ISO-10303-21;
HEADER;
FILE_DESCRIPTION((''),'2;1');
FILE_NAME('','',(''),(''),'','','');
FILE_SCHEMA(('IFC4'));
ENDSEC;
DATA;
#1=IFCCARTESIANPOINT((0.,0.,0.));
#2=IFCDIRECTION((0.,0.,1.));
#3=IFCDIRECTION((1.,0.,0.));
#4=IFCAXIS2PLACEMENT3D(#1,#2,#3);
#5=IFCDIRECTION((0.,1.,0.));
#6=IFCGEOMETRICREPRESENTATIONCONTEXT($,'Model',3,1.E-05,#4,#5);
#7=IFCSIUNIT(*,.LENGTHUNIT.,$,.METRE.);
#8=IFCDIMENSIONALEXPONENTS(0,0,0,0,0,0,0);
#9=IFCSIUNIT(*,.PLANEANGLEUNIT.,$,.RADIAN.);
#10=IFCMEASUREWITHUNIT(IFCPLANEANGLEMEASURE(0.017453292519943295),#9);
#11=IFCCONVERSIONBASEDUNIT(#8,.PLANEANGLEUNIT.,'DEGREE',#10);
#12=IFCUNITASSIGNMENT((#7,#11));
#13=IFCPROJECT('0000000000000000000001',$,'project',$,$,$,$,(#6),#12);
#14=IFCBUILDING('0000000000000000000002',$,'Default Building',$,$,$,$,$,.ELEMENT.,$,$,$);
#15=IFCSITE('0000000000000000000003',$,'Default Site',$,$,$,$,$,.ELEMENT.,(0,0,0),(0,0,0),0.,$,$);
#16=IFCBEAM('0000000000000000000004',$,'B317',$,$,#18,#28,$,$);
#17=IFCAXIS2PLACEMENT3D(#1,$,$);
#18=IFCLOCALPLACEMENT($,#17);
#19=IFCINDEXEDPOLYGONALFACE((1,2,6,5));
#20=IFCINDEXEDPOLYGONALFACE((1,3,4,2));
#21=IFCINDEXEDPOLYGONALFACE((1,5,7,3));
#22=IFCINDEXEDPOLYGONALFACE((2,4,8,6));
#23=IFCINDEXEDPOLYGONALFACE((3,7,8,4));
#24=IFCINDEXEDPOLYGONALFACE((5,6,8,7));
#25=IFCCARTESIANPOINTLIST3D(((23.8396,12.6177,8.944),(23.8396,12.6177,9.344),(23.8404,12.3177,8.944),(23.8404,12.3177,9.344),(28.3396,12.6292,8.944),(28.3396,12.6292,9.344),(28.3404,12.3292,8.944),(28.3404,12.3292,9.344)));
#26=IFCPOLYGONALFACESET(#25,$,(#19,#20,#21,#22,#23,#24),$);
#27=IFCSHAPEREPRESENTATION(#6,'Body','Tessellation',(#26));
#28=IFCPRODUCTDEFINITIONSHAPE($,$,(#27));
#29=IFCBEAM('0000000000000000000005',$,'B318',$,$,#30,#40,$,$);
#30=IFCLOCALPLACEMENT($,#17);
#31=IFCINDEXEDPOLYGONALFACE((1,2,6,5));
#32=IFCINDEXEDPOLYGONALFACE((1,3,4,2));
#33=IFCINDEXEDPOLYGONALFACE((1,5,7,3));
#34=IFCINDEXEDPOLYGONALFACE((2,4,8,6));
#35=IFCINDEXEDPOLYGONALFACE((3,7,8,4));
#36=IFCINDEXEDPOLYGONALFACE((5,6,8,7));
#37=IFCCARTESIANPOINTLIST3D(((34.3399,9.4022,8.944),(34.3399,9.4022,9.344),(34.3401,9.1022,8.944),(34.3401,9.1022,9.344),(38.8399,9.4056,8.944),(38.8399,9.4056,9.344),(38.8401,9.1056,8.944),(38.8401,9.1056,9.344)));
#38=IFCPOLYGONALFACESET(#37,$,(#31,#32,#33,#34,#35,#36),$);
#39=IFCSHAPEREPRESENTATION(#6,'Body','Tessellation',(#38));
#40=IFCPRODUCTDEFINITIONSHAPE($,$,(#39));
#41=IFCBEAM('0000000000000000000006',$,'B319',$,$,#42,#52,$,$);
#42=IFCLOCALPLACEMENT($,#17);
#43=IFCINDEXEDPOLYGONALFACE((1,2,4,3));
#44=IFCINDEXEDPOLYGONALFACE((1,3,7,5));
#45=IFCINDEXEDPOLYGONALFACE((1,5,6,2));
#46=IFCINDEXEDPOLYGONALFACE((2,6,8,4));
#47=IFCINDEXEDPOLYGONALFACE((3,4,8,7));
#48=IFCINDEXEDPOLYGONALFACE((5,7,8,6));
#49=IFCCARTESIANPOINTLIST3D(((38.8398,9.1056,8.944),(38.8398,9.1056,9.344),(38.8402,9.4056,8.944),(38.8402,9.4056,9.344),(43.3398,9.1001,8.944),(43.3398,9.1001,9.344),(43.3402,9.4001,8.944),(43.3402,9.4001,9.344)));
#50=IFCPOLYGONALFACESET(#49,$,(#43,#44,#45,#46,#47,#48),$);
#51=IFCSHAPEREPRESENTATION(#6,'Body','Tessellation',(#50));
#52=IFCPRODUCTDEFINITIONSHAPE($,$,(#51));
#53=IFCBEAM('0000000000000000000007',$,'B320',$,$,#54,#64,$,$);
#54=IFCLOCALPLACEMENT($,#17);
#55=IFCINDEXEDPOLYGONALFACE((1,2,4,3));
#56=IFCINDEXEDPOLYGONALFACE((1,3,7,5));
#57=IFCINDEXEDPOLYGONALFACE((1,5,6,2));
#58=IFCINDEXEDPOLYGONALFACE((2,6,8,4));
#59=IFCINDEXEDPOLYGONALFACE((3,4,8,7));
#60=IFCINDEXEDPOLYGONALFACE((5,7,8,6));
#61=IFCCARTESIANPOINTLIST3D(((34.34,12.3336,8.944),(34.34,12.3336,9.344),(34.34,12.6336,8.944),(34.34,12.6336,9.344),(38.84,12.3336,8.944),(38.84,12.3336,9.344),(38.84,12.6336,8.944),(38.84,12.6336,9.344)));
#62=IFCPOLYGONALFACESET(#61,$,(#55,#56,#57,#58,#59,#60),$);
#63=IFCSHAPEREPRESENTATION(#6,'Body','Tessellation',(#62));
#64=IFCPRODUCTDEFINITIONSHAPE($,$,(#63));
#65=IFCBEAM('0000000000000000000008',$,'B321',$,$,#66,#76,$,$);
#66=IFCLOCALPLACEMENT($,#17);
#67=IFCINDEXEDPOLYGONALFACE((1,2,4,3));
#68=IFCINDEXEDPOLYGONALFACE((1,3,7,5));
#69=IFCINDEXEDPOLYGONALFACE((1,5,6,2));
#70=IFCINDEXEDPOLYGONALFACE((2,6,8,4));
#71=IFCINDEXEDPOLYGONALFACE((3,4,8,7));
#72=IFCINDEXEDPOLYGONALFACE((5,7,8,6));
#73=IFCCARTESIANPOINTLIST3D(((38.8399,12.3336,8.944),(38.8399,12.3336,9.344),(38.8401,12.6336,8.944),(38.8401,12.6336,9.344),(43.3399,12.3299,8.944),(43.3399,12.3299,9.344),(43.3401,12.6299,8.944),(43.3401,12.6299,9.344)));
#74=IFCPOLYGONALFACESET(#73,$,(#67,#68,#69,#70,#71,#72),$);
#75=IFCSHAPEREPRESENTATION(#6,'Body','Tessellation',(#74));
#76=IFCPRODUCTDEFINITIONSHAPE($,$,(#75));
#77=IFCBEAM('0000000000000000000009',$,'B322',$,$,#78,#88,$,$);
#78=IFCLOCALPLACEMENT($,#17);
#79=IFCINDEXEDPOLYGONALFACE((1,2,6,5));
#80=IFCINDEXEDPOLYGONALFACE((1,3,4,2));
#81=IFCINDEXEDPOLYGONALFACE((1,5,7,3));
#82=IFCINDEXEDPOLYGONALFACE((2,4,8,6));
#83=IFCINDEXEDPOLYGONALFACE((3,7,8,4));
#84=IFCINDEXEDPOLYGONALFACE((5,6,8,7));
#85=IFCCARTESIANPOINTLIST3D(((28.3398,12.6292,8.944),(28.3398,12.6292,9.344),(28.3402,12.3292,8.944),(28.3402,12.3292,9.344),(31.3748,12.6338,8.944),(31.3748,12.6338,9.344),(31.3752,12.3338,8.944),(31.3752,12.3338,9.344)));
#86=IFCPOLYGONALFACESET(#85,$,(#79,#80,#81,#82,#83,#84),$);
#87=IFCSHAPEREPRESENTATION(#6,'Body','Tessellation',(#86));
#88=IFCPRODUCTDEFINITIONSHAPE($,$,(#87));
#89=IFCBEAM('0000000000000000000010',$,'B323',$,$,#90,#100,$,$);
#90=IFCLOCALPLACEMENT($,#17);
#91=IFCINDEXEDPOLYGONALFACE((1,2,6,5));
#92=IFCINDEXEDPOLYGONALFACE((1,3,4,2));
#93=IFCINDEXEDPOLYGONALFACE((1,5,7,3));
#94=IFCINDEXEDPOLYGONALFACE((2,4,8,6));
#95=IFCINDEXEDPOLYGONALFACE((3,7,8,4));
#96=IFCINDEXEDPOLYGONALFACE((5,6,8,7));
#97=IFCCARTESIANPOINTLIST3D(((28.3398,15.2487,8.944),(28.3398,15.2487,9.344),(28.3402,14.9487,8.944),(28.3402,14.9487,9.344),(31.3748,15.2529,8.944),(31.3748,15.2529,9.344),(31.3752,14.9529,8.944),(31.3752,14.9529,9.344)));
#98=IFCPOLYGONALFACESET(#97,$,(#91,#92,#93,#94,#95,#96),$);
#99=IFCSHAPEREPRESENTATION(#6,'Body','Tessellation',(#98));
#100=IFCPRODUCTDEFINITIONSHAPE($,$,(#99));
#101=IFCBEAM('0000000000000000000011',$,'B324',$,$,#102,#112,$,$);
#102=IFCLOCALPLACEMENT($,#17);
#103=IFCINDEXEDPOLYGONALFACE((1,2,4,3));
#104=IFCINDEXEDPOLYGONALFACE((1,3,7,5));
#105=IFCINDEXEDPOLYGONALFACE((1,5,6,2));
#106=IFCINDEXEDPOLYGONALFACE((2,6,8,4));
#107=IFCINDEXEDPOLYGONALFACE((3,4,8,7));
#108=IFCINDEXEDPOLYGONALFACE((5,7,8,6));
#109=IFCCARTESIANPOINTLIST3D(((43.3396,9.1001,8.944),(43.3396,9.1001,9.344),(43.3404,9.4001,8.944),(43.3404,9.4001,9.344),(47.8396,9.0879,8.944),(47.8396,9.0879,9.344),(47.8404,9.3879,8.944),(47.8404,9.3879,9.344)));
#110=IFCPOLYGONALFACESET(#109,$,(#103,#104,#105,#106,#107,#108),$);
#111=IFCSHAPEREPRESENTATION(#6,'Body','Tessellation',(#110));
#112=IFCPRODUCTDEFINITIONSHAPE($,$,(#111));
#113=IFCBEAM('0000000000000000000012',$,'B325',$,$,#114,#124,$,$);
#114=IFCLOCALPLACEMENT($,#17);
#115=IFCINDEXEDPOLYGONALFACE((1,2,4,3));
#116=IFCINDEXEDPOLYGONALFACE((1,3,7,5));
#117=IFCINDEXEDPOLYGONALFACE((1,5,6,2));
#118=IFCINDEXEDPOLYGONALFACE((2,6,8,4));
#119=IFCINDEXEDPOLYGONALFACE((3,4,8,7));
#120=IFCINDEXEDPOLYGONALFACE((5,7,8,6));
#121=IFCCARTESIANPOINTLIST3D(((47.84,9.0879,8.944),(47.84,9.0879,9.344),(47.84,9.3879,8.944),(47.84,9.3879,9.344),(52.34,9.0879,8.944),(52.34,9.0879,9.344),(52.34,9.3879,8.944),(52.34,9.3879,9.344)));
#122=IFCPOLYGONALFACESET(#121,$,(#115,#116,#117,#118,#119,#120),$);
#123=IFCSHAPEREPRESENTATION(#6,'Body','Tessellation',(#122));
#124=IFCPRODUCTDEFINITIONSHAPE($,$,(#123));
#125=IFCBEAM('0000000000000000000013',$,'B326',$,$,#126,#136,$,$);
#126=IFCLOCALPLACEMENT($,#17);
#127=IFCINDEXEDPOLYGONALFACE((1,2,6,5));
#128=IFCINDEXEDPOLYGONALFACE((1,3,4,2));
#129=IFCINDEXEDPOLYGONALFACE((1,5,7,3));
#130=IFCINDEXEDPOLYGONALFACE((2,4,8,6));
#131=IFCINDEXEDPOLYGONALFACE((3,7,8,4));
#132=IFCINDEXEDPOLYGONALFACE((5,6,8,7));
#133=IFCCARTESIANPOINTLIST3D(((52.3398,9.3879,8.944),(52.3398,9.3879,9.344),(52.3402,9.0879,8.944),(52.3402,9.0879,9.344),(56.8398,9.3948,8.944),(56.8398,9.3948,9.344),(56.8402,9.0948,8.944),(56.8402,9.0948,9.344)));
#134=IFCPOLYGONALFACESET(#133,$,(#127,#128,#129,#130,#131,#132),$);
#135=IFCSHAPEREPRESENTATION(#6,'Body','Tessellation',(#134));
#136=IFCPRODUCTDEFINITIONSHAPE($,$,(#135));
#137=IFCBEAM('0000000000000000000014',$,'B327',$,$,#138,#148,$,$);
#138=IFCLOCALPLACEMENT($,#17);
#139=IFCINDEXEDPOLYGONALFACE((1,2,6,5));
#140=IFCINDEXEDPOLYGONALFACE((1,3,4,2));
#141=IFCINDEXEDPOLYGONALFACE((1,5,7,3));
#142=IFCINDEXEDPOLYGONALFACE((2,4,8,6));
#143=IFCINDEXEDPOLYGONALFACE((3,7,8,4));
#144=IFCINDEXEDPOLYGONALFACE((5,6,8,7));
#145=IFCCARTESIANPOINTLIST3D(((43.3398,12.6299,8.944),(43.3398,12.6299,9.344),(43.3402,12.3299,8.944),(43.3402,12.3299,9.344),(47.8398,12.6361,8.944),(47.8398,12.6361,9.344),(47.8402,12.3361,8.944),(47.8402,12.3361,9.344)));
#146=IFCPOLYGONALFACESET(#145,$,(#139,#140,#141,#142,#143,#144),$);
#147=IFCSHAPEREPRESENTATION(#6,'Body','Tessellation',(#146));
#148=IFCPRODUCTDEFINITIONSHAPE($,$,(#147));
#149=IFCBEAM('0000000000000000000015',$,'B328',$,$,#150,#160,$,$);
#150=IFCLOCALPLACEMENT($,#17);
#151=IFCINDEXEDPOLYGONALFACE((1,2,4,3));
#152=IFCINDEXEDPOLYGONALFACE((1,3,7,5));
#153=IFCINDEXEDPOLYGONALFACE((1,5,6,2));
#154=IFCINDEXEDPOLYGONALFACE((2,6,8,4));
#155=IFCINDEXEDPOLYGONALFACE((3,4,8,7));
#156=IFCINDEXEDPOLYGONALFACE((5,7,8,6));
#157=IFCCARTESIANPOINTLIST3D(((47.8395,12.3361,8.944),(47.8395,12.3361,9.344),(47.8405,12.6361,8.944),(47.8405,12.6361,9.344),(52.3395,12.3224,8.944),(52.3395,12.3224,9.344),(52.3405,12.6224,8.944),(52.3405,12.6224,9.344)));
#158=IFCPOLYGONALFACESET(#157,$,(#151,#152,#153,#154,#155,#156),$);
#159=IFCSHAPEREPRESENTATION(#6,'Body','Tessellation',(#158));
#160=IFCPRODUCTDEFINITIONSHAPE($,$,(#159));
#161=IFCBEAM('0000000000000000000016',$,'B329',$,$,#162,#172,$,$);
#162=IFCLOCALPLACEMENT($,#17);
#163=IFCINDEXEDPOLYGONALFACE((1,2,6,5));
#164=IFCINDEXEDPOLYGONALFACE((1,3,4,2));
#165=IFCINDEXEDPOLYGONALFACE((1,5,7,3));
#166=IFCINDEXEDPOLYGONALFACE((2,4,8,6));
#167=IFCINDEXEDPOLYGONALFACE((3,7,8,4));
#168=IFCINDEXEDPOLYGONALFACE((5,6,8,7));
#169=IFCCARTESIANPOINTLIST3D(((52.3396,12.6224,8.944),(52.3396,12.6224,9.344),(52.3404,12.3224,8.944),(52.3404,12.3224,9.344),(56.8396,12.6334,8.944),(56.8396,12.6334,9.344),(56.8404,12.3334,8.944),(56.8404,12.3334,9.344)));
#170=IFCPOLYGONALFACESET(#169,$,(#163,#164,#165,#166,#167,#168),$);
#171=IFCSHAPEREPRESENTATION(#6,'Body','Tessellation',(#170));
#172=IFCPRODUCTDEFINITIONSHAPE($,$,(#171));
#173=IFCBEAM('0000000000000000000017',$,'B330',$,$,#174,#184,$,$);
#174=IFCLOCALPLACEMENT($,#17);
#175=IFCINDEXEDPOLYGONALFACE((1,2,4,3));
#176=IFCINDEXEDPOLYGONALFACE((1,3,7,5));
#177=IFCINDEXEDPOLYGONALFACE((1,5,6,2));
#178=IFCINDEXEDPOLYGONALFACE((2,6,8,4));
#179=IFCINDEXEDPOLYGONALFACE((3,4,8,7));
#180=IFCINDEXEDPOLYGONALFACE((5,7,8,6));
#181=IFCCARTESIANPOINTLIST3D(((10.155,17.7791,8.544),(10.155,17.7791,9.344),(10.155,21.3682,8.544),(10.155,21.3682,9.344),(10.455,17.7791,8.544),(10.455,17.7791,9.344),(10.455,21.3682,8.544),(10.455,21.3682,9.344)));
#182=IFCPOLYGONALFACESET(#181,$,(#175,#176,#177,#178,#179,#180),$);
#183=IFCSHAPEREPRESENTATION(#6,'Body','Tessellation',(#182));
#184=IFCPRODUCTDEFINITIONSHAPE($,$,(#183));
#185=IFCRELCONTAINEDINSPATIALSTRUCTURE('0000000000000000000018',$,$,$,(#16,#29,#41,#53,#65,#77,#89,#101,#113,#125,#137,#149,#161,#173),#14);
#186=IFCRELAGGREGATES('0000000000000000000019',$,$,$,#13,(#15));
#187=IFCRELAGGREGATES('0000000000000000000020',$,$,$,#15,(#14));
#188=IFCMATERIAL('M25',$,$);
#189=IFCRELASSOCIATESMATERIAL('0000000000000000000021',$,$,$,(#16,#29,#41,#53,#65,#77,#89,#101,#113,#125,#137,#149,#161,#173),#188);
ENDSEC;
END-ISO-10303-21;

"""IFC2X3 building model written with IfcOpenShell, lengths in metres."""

from ifc_helpers import new_model, entity, si_unit, converted_unit, direction, frame, frame_2d, origin_with_axes, place, context, project, spatial, rectangle, extrude, material, element, save


model = new_model("IFC2X3")

# Units and contexts
model_context = context("Model", 3, precision=1e-05, world=origin_with_axes(), true_north=direction((0.0, 1.0, 0.0)))
ifc_project = project(units=[si_unit("LENGTHUNIT", "METRE"), converted_unit("PLANEANGLEUNIT", "DEGREE", entity("IfcPlaneAngleMeasure", 0.017453292519943295), si_unit("PLANEANGLEUNIT", "RADIAN"), dimensions=[0, 0, 0, 0, 0, 0, 0])], contexts=[model_context])

# Site, building
site = spatial("IfcSite", under=ifc_project, Name="Default Site", CompositionType="ELEMENT", RefLatitude=(0, 0, 0), RefLongitude=(0, 0, 0), RefElevation=0.0)
building = spatial("IfcBuilding", under=site, Name="Default Building", CompositionType="ELEMENT")

# Beams
ifc_material = material(Name="M25")
placement = place(None, origin_with_axes())
element("IfcBeam", 1, at=placement, inside=building, material=ifc_material, Name="B317", context=model_context, shape_type="SweptSolid", body=[
    extrude(rectangle(XDim=0.3, YDim=0.4, at=frame_2d((0.0, 0.0), x_axis=(0.0, 1.0, 0.0))), frame((23.84, 12.4677, 9.144), z_axis=(0.999997, 0.002551, 0.0), x_axis=(0.0, 0.0, -1.0)), (0.0, 0.0, 1.0), 4.5),
])
element("IfcBeam", 2, at=placement, inside=building, material=ifc_material, Name="B318", context=model_context, shape_type="SweptSolid", body=[
    extrude(rectangle(XDim=0.3, YDim=0.4, at=frame_2d((0.0, 0.0), x_axis=(0.0, 1.0, 0.0))), frame((34.34, 9.2522, 9.144), z_axis=(1.0, 0.000748, 0.0), x_axis=(0.0, 0.0, -1.0)), (0.0, 0.0, 1.0), 4.5),
])
element("IfcBeam", 3, at=placement, inside=building, material=ifc_material, Name="B319", context=model_context, shape_type="SweptSolid", body=[
    extrude(rectangle(XDim=0.3, YDim=0.4, at=frame_2d((0.0, 0.0), x_axis=(0.0, 1.0, 0.0))), frame((38.84, 9.2556, 9.144), z_axis=(0.999999, -0.001227, 0.0), x_axis=(0.0, 0.0, -1.0)), (0.0, 0.0, 1.0), 4.5),
])
element("IfcBeam", 4, at=placement, inside=building, material=ifc_material, Name="B320", context=model_context, shape_type="SweptSolid", body=[
    extrude(rectangle(XDim=0.3, YDim=0.4, at=frame_2d((0.0, 0.0), x_axis=(0.0, 1.0, 0.0))), frame((34.34, 12.4836, 9.144), z_axis=(1.0, -0.000008, 0.0), x_axis=(0.0, 0.0, -1.0)), (0.0, 0.0, 1.0), 4.5),
])
element("IfcBeam", 5, at=placement, inside=building, material=ifc_material, Name="B321", context=model_context, shape_type="SweptSolid", body=[
    extrude(rectangle(XDim=0.3, YDim=0.4, at=frame_2d((0.0, 0.0), x_axis=(0.0, 1.0, 0.0))), frame((38.84, 12.4836, 9.144), z_axis=(1.0, -0.000826, 0.0), x_axis=(0.0, 0.0, -1.0)), (0.0, 0.0, 1.0), 4.5),
])
element("IfcBeam", 6, at=placement, inside=building, material=ifc_material, Name="B322", context=model_context, shape_type="SweptSolid", body=[
    extrude(rectangle(XDim=0.3, YDim=0.4, at=frame_2d((0.0, 0.0), x_axis=(0.0, 1.0, 0.0))), frame((28.34, 12.4792, 9.144), z_axis=(0.999999, 0.001542, 0.0), x_axis=(0.0, 0.0, -1.0)), (0.0, 0.0, 1.0), 3.035),
])
element("IfcBeam", 7, at=placement, inside=building, material=ifc_material, Name="B323", context=model_context, shape_type="SweptSolid", body=[
    extrude(rectangle(XDim=0.3, YDim=0.4, at=frame_2d((0.0, 0.0), x_axis=(0.0, 1.0, 0.0))), frame((31.375, 15.1029, 9.144), z_axis=(-0.999999, -0.001391, 0.0), x_axis=(0.0, 0.0, -1.0)), (0.0, 0.0, 1.0), 3.035),
])
element("IfcBeam", 8, at=placement, inside=building, material=ifc_material, Name="B324", context=model_context, shape_type="SweptSolid", body=[
    extrude(rectangle(XDim=0.3, YDim=0.4, at=frame_2d((0.0, 0.0), x_axis=(0.0, 1.0, 0.0))), frame((43.34, 9.2501, 9.144), z_axis=(0.999996, -0.002702, 0.0), x_axis=(0.0, 0.0, -1.0)), (0.0, 0.0, 1.0), 4.5),
])
element("IfcBeam", 9, at=placement, inside=building, material=ifc_material, Name="B325", context=model_context, shape_type="SweptSolid", body=[
    extrude(rectangle(XDim=0.3, YDim=0.4, at=frame_2d((0.0, 0.0), x_axis=(0.0, 1.0, 0.0))), frame((47.84, 9.2379, 9.144), z_axis=(1.0, 0.0, 0.0), x_axis=(0.0, 0.0, -1.0)), (0.0, 0.0, 1.0), 4.5),
])
element("IfcBeam", 10, at=placement, inside=building, material=ifc_material, Name="B326", context=model_context, shape_type="SweptSolid", body=[
    extrude(rectangle(XDim=0.3, YDim=0.4, at=frame_2d((0.0, 0.0), x_axis=(0.0, 1.0, 0.0))), frame((52.34, 9.2379, 9.144), z_axis=(0.999999, 0.001537, 0.0), x_axis=(0.0, 0.0, -1.0)), (0.0, 0.0, 1.0), 4.5),
])
element("IfcBeam", 11, at=placement, inside=building, material=ifc_material, Name="B327", context=model_context, shape_type="SweptSolid", body=[
    extrude(rectangle(XDim=0.3, YDim=0.4, at=frame_2d((0.0, 0.0), x_axis=(0.0, 1.0, 0.0))), frame((43.34, 12.4799, 9.144), z_axis=(0.999999, 0.001374, 0.0), x_axis=(0.0, 0.0, -1.0)), (0.0, 0.0, 1.0), 4.5),
])
element("IfcBeam", 12, at=placement, inside=building, material=ifc_material, Name="B328", context=model_context, shape_type="SweptSolid", body=[
    extrude(rectangle(XDim=0.3, YDim=0.4, at=frame_2d((0.0, 0.0), x_axis=(0.0, 1.0, 0.0))), frame((47.84, 12.4861, 9.144), z_axis=(0.999995, -0.003045, 0.0), x_axis=(0.0, 0.0, -1.0)), (0.0, 0.0, 1.0), 4.5),
])
element("IfcBeam", 13, at=placement, inside=building, material=ifc_material, Name="B329", context=model_context, shape_type="SweptSolid", body=[
    extrude(rectangle(XDim=0.3, YDim=0.4, at=frame_2d((0.0, 0.0), x_axis=(0.0, 1.0, 0.0))), frame((52.34, 12.4724, 9.144), z_axis=(0.999997, 0.002456, 0.0), x_axis=(0.0, 0.0, -1.0)), (0.0, 0.0, 1.0), 4.5),
])
element("IfcBeam", 14, at=placement, inside=building, material=ifc_material, Name="B330", context=model_context, shape_type="SweptSolid", body=[
    extrude(rectangle(XDim=0.3, YDim=0.8, at=frame_2d((0.0, 0.0), x_axis=(0.0, 1.0, 0.0))), frame((10.305, 21.3682, 8.944), z_axis=(0.0, -1.0, 0.0), x_axis=(0.0, 0.0, -1.0)), (0.0, 0.0, 1.0), 3.5891),
])

save(model, "model.ifc")
